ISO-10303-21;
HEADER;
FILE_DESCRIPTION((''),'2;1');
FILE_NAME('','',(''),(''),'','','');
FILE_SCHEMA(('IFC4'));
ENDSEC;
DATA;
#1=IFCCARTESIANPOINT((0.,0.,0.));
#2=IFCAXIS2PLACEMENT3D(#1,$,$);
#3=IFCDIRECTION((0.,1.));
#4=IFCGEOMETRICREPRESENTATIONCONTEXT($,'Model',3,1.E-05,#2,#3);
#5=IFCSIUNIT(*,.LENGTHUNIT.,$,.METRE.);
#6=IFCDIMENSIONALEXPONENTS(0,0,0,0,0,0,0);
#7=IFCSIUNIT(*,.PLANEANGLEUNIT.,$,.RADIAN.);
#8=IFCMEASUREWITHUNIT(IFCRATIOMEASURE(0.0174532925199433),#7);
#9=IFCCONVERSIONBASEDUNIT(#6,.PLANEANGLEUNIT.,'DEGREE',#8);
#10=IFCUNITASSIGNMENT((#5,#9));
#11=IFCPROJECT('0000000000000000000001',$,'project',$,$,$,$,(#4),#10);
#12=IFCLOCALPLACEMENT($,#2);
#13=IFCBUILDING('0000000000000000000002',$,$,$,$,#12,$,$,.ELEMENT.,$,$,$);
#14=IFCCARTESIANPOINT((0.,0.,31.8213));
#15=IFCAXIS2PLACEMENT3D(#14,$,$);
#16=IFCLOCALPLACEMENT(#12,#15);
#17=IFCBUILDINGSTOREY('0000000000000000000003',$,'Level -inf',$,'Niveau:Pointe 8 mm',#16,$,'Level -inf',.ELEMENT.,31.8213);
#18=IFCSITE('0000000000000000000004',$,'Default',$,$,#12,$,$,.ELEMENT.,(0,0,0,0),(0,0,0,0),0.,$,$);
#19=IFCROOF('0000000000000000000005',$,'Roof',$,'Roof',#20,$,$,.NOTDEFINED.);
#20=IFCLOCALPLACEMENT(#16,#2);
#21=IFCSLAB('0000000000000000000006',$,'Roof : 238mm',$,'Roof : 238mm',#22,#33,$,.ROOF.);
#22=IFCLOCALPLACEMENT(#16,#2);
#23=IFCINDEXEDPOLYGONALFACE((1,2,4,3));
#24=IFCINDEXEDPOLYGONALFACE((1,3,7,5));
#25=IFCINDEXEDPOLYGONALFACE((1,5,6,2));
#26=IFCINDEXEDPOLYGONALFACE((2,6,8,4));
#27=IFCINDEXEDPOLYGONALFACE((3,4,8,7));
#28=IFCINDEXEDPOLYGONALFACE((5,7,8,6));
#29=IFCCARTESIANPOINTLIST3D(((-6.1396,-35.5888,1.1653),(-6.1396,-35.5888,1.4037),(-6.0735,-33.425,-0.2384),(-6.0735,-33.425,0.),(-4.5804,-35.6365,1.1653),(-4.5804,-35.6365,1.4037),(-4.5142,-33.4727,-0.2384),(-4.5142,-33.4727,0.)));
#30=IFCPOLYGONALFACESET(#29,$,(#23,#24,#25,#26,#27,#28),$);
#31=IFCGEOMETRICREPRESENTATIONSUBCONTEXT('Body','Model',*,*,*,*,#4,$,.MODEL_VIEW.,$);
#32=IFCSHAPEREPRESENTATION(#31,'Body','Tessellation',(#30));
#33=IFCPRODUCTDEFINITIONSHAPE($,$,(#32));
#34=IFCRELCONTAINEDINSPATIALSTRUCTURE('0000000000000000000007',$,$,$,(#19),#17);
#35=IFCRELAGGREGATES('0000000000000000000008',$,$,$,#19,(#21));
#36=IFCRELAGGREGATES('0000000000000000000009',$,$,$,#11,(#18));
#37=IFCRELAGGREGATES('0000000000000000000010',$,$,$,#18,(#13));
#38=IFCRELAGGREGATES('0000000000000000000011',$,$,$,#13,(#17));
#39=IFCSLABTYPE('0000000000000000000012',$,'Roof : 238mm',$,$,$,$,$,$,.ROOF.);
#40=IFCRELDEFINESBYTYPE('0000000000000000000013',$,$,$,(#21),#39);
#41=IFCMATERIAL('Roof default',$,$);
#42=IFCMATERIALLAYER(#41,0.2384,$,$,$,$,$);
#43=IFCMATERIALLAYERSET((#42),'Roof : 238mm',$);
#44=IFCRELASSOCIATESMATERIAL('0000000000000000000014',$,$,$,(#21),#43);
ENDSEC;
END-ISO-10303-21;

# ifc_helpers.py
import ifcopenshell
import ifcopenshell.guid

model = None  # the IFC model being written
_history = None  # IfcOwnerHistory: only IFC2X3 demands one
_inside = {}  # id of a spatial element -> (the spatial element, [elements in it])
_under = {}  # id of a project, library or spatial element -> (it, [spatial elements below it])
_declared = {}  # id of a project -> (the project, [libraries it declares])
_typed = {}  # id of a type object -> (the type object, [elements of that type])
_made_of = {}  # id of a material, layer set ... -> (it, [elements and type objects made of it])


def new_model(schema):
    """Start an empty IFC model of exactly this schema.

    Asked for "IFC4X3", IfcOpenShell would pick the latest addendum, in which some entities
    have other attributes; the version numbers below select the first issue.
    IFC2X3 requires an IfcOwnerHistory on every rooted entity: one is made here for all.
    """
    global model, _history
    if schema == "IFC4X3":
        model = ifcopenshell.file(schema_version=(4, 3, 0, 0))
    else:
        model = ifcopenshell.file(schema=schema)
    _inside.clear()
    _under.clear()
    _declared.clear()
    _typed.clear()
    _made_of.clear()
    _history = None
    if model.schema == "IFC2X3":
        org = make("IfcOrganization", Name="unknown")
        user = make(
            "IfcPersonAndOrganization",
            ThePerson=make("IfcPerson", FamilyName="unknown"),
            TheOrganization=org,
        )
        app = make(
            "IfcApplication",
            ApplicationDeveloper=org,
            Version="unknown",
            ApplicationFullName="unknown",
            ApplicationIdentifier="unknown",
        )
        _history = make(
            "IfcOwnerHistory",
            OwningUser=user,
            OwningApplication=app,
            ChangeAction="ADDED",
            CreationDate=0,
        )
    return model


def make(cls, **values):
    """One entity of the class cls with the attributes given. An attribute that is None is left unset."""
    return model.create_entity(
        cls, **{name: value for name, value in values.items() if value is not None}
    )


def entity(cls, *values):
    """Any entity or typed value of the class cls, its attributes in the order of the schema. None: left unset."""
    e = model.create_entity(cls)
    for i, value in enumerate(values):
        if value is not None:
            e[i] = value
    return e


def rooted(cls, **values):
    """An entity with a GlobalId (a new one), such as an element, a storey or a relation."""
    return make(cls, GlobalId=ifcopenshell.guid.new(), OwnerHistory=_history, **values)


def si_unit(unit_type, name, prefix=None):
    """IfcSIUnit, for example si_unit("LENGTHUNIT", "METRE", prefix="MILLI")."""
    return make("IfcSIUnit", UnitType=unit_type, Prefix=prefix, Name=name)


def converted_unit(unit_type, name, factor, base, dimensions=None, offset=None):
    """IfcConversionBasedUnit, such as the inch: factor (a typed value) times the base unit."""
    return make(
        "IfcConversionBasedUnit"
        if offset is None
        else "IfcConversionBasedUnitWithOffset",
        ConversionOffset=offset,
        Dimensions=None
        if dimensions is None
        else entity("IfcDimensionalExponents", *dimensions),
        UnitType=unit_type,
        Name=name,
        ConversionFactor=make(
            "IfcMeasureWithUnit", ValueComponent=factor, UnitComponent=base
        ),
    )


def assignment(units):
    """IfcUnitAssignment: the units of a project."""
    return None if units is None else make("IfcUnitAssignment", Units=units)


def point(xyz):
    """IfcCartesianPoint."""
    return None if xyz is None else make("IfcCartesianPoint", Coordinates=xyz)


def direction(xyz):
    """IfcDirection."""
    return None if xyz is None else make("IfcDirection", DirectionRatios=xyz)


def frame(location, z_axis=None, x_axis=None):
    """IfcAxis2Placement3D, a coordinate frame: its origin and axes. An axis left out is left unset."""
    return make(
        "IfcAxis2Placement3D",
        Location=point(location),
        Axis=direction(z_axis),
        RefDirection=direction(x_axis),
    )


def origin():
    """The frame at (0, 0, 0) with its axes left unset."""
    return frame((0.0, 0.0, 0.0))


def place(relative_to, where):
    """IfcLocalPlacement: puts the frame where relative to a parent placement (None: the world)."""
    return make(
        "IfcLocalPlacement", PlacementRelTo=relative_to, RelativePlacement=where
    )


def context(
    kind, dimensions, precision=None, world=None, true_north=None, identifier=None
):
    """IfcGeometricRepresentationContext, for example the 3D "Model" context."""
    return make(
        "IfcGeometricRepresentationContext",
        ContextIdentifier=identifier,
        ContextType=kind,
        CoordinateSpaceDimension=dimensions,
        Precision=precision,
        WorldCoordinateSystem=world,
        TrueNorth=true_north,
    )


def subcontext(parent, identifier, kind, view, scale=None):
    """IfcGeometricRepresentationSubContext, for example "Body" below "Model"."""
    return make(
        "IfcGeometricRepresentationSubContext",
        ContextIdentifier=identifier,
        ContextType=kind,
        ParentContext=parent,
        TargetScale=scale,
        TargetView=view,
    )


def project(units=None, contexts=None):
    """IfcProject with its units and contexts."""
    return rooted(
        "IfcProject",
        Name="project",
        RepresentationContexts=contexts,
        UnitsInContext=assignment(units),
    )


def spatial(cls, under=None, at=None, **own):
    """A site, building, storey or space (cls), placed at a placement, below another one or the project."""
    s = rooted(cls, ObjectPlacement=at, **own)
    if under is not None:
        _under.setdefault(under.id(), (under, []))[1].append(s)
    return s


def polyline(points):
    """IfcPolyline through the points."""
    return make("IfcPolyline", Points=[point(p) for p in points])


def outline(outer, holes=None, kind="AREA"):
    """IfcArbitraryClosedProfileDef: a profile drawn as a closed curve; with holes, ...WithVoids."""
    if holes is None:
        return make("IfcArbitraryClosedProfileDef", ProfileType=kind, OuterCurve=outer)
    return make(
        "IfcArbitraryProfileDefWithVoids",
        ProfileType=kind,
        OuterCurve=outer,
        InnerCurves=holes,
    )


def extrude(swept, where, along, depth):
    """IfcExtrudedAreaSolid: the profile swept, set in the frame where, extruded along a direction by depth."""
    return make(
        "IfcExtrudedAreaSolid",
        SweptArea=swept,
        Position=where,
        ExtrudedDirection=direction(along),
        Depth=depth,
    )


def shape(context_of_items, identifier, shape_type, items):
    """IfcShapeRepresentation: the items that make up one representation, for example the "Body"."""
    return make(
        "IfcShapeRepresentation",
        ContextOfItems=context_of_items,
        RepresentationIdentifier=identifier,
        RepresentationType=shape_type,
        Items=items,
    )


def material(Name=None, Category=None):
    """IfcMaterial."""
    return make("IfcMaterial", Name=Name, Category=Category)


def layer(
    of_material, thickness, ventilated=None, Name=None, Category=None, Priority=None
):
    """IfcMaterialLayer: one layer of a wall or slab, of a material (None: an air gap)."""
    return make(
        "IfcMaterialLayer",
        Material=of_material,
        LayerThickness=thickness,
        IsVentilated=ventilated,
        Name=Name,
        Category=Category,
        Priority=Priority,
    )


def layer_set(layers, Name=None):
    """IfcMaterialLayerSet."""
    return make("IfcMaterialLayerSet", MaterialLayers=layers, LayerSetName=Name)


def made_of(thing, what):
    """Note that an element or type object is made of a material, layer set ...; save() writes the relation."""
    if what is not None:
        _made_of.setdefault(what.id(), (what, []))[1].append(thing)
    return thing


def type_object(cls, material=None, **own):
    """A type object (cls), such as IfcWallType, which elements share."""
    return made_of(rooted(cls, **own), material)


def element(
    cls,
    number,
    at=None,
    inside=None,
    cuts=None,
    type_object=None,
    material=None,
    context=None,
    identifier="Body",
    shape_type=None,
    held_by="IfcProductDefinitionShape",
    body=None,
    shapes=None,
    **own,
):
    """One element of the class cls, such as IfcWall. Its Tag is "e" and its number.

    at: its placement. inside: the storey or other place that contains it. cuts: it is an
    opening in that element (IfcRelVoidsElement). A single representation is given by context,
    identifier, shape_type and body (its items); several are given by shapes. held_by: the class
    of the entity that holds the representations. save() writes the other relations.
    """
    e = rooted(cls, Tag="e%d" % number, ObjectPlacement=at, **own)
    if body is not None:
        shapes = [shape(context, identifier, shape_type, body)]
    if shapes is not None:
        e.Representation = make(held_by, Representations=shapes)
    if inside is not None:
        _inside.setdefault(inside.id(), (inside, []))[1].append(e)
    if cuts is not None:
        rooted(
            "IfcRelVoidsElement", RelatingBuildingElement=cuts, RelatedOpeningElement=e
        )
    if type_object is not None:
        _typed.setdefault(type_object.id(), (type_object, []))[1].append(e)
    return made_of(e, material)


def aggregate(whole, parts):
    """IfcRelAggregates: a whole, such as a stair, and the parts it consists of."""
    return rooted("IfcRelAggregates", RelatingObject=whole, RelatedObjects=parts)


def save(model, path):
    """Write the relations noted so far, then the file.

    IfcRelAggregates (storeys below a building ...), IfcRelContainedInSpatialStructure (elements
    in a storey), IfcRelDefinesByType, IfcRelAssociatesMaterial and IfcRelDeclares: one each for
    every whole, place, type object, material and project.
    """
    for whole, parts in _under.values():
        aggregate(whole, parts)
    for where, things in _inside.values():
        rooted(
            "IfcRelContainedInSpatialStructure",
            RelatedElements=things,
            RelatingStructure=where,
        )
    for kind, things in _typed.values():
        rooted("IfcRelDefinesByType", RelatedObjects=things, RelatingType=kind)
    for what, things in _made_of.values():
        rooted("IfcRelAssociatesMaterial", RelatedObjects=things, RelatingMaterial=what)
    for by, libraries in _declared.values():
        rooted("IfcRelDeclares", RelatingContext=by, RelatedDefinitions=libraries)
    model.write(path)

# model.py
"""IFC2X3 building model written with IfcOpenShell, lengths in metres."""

from ifc_helpers import new_model, entity, si_unit, converted_unit, direction, frame, origin, place, context, subcontext, project, spatial, polyline, outline, extrude, material, layer, layer_set, type_object, element, aggregate, save


model = new_model("IFC2X3")

# Units and contexts
model_context = context("Model", 3, precision=1e-05, world=origin(), true_north=direction((0.0, 1.0)))
body_context = subcontext(model_context, "Body", "Model", "MODEL_VIEW")
ifc_project = project(units=[si_unit("LENGTHUNIT", "METRE"), converted_unit("PLANEANGLEUNIT", "DEGREE", entity("IfcRatioMeasure", 0.0174532925199433), si_unit("PLANEANGLEUNIT", "RADIAN"), dimensions=[0, 0, 0, 0, 0, 0, 0])], contexts=[model_context])

# Site, building, storey
placement_1 = place(None, origin())
site = spatial("IfcSite", under=ifc_project, at=placement_1, Name="Default", CompositionType="ELEMENT", RefLatitude=(0, 0, 0, 0), RefLongitude=(0, 0, 0, 0), RefElevation=0.0)
building = spatial("IfcBuilding", under=site, at=placement_1, CompositionType="ELEMENT")
storey_placement = place(placement_1, frame((0.0, 0.0, 31.8213)))
storey = spatial("IfcBuildingStorey", under=building, at=storey_placement, Name="Level -inf", ObjectType="Niveau:Pointe 8 mm", LongName="Level -inf", CompositionType="ELEMENT", Elevation=31.8213)

# Roof, slab
placement_2 = place(storey_placement, frame((-6.0735, -33.425, 0.0)))
roof = element("IfcRoof", 1, at=placement_2, inside=storey, Name="Roof", ObjectType="Roof", ShapeType="NOTDEFINED")
ifc_material = material(Name="Roof default")
ifc_layer_1 = layer(ifc_material, 0.2384)
ifc_layer_set_1 = layer_set([ifc_layer_1], Name="Roof : 238mm")
slab_type_1 = type_object("IfcSlabType", Name="Roof : 238mm", PredefinedType="ROOF")
slab_1 = element("IfcSlab", 2, at=placement_2, type_object=slab_type_1, material=ifc_layer_set_1, Name="Roof : 238mm", ObjectType="Roof : 238mm", PredefinedType="ROOF", context=body_context, shape_type="SweptSolid", body=[
    extrude(outline(polyline([(-0.78, 1.29), (0.78, 1.29), (0.78, -1.29), (-0.78, -1.29), (-0.78, 1.29)])), frame((0.7466, -1.1057, 0.7018), z_axis=(0.016631, 0.543804, 0.839048), x_axis=(0.999533, -0.030569, 0.0)), (0.0, 0.544058, -0.839048), 0.2384),
])
aggregate(roof, [slab_1])

save(model, "model.ifc")
